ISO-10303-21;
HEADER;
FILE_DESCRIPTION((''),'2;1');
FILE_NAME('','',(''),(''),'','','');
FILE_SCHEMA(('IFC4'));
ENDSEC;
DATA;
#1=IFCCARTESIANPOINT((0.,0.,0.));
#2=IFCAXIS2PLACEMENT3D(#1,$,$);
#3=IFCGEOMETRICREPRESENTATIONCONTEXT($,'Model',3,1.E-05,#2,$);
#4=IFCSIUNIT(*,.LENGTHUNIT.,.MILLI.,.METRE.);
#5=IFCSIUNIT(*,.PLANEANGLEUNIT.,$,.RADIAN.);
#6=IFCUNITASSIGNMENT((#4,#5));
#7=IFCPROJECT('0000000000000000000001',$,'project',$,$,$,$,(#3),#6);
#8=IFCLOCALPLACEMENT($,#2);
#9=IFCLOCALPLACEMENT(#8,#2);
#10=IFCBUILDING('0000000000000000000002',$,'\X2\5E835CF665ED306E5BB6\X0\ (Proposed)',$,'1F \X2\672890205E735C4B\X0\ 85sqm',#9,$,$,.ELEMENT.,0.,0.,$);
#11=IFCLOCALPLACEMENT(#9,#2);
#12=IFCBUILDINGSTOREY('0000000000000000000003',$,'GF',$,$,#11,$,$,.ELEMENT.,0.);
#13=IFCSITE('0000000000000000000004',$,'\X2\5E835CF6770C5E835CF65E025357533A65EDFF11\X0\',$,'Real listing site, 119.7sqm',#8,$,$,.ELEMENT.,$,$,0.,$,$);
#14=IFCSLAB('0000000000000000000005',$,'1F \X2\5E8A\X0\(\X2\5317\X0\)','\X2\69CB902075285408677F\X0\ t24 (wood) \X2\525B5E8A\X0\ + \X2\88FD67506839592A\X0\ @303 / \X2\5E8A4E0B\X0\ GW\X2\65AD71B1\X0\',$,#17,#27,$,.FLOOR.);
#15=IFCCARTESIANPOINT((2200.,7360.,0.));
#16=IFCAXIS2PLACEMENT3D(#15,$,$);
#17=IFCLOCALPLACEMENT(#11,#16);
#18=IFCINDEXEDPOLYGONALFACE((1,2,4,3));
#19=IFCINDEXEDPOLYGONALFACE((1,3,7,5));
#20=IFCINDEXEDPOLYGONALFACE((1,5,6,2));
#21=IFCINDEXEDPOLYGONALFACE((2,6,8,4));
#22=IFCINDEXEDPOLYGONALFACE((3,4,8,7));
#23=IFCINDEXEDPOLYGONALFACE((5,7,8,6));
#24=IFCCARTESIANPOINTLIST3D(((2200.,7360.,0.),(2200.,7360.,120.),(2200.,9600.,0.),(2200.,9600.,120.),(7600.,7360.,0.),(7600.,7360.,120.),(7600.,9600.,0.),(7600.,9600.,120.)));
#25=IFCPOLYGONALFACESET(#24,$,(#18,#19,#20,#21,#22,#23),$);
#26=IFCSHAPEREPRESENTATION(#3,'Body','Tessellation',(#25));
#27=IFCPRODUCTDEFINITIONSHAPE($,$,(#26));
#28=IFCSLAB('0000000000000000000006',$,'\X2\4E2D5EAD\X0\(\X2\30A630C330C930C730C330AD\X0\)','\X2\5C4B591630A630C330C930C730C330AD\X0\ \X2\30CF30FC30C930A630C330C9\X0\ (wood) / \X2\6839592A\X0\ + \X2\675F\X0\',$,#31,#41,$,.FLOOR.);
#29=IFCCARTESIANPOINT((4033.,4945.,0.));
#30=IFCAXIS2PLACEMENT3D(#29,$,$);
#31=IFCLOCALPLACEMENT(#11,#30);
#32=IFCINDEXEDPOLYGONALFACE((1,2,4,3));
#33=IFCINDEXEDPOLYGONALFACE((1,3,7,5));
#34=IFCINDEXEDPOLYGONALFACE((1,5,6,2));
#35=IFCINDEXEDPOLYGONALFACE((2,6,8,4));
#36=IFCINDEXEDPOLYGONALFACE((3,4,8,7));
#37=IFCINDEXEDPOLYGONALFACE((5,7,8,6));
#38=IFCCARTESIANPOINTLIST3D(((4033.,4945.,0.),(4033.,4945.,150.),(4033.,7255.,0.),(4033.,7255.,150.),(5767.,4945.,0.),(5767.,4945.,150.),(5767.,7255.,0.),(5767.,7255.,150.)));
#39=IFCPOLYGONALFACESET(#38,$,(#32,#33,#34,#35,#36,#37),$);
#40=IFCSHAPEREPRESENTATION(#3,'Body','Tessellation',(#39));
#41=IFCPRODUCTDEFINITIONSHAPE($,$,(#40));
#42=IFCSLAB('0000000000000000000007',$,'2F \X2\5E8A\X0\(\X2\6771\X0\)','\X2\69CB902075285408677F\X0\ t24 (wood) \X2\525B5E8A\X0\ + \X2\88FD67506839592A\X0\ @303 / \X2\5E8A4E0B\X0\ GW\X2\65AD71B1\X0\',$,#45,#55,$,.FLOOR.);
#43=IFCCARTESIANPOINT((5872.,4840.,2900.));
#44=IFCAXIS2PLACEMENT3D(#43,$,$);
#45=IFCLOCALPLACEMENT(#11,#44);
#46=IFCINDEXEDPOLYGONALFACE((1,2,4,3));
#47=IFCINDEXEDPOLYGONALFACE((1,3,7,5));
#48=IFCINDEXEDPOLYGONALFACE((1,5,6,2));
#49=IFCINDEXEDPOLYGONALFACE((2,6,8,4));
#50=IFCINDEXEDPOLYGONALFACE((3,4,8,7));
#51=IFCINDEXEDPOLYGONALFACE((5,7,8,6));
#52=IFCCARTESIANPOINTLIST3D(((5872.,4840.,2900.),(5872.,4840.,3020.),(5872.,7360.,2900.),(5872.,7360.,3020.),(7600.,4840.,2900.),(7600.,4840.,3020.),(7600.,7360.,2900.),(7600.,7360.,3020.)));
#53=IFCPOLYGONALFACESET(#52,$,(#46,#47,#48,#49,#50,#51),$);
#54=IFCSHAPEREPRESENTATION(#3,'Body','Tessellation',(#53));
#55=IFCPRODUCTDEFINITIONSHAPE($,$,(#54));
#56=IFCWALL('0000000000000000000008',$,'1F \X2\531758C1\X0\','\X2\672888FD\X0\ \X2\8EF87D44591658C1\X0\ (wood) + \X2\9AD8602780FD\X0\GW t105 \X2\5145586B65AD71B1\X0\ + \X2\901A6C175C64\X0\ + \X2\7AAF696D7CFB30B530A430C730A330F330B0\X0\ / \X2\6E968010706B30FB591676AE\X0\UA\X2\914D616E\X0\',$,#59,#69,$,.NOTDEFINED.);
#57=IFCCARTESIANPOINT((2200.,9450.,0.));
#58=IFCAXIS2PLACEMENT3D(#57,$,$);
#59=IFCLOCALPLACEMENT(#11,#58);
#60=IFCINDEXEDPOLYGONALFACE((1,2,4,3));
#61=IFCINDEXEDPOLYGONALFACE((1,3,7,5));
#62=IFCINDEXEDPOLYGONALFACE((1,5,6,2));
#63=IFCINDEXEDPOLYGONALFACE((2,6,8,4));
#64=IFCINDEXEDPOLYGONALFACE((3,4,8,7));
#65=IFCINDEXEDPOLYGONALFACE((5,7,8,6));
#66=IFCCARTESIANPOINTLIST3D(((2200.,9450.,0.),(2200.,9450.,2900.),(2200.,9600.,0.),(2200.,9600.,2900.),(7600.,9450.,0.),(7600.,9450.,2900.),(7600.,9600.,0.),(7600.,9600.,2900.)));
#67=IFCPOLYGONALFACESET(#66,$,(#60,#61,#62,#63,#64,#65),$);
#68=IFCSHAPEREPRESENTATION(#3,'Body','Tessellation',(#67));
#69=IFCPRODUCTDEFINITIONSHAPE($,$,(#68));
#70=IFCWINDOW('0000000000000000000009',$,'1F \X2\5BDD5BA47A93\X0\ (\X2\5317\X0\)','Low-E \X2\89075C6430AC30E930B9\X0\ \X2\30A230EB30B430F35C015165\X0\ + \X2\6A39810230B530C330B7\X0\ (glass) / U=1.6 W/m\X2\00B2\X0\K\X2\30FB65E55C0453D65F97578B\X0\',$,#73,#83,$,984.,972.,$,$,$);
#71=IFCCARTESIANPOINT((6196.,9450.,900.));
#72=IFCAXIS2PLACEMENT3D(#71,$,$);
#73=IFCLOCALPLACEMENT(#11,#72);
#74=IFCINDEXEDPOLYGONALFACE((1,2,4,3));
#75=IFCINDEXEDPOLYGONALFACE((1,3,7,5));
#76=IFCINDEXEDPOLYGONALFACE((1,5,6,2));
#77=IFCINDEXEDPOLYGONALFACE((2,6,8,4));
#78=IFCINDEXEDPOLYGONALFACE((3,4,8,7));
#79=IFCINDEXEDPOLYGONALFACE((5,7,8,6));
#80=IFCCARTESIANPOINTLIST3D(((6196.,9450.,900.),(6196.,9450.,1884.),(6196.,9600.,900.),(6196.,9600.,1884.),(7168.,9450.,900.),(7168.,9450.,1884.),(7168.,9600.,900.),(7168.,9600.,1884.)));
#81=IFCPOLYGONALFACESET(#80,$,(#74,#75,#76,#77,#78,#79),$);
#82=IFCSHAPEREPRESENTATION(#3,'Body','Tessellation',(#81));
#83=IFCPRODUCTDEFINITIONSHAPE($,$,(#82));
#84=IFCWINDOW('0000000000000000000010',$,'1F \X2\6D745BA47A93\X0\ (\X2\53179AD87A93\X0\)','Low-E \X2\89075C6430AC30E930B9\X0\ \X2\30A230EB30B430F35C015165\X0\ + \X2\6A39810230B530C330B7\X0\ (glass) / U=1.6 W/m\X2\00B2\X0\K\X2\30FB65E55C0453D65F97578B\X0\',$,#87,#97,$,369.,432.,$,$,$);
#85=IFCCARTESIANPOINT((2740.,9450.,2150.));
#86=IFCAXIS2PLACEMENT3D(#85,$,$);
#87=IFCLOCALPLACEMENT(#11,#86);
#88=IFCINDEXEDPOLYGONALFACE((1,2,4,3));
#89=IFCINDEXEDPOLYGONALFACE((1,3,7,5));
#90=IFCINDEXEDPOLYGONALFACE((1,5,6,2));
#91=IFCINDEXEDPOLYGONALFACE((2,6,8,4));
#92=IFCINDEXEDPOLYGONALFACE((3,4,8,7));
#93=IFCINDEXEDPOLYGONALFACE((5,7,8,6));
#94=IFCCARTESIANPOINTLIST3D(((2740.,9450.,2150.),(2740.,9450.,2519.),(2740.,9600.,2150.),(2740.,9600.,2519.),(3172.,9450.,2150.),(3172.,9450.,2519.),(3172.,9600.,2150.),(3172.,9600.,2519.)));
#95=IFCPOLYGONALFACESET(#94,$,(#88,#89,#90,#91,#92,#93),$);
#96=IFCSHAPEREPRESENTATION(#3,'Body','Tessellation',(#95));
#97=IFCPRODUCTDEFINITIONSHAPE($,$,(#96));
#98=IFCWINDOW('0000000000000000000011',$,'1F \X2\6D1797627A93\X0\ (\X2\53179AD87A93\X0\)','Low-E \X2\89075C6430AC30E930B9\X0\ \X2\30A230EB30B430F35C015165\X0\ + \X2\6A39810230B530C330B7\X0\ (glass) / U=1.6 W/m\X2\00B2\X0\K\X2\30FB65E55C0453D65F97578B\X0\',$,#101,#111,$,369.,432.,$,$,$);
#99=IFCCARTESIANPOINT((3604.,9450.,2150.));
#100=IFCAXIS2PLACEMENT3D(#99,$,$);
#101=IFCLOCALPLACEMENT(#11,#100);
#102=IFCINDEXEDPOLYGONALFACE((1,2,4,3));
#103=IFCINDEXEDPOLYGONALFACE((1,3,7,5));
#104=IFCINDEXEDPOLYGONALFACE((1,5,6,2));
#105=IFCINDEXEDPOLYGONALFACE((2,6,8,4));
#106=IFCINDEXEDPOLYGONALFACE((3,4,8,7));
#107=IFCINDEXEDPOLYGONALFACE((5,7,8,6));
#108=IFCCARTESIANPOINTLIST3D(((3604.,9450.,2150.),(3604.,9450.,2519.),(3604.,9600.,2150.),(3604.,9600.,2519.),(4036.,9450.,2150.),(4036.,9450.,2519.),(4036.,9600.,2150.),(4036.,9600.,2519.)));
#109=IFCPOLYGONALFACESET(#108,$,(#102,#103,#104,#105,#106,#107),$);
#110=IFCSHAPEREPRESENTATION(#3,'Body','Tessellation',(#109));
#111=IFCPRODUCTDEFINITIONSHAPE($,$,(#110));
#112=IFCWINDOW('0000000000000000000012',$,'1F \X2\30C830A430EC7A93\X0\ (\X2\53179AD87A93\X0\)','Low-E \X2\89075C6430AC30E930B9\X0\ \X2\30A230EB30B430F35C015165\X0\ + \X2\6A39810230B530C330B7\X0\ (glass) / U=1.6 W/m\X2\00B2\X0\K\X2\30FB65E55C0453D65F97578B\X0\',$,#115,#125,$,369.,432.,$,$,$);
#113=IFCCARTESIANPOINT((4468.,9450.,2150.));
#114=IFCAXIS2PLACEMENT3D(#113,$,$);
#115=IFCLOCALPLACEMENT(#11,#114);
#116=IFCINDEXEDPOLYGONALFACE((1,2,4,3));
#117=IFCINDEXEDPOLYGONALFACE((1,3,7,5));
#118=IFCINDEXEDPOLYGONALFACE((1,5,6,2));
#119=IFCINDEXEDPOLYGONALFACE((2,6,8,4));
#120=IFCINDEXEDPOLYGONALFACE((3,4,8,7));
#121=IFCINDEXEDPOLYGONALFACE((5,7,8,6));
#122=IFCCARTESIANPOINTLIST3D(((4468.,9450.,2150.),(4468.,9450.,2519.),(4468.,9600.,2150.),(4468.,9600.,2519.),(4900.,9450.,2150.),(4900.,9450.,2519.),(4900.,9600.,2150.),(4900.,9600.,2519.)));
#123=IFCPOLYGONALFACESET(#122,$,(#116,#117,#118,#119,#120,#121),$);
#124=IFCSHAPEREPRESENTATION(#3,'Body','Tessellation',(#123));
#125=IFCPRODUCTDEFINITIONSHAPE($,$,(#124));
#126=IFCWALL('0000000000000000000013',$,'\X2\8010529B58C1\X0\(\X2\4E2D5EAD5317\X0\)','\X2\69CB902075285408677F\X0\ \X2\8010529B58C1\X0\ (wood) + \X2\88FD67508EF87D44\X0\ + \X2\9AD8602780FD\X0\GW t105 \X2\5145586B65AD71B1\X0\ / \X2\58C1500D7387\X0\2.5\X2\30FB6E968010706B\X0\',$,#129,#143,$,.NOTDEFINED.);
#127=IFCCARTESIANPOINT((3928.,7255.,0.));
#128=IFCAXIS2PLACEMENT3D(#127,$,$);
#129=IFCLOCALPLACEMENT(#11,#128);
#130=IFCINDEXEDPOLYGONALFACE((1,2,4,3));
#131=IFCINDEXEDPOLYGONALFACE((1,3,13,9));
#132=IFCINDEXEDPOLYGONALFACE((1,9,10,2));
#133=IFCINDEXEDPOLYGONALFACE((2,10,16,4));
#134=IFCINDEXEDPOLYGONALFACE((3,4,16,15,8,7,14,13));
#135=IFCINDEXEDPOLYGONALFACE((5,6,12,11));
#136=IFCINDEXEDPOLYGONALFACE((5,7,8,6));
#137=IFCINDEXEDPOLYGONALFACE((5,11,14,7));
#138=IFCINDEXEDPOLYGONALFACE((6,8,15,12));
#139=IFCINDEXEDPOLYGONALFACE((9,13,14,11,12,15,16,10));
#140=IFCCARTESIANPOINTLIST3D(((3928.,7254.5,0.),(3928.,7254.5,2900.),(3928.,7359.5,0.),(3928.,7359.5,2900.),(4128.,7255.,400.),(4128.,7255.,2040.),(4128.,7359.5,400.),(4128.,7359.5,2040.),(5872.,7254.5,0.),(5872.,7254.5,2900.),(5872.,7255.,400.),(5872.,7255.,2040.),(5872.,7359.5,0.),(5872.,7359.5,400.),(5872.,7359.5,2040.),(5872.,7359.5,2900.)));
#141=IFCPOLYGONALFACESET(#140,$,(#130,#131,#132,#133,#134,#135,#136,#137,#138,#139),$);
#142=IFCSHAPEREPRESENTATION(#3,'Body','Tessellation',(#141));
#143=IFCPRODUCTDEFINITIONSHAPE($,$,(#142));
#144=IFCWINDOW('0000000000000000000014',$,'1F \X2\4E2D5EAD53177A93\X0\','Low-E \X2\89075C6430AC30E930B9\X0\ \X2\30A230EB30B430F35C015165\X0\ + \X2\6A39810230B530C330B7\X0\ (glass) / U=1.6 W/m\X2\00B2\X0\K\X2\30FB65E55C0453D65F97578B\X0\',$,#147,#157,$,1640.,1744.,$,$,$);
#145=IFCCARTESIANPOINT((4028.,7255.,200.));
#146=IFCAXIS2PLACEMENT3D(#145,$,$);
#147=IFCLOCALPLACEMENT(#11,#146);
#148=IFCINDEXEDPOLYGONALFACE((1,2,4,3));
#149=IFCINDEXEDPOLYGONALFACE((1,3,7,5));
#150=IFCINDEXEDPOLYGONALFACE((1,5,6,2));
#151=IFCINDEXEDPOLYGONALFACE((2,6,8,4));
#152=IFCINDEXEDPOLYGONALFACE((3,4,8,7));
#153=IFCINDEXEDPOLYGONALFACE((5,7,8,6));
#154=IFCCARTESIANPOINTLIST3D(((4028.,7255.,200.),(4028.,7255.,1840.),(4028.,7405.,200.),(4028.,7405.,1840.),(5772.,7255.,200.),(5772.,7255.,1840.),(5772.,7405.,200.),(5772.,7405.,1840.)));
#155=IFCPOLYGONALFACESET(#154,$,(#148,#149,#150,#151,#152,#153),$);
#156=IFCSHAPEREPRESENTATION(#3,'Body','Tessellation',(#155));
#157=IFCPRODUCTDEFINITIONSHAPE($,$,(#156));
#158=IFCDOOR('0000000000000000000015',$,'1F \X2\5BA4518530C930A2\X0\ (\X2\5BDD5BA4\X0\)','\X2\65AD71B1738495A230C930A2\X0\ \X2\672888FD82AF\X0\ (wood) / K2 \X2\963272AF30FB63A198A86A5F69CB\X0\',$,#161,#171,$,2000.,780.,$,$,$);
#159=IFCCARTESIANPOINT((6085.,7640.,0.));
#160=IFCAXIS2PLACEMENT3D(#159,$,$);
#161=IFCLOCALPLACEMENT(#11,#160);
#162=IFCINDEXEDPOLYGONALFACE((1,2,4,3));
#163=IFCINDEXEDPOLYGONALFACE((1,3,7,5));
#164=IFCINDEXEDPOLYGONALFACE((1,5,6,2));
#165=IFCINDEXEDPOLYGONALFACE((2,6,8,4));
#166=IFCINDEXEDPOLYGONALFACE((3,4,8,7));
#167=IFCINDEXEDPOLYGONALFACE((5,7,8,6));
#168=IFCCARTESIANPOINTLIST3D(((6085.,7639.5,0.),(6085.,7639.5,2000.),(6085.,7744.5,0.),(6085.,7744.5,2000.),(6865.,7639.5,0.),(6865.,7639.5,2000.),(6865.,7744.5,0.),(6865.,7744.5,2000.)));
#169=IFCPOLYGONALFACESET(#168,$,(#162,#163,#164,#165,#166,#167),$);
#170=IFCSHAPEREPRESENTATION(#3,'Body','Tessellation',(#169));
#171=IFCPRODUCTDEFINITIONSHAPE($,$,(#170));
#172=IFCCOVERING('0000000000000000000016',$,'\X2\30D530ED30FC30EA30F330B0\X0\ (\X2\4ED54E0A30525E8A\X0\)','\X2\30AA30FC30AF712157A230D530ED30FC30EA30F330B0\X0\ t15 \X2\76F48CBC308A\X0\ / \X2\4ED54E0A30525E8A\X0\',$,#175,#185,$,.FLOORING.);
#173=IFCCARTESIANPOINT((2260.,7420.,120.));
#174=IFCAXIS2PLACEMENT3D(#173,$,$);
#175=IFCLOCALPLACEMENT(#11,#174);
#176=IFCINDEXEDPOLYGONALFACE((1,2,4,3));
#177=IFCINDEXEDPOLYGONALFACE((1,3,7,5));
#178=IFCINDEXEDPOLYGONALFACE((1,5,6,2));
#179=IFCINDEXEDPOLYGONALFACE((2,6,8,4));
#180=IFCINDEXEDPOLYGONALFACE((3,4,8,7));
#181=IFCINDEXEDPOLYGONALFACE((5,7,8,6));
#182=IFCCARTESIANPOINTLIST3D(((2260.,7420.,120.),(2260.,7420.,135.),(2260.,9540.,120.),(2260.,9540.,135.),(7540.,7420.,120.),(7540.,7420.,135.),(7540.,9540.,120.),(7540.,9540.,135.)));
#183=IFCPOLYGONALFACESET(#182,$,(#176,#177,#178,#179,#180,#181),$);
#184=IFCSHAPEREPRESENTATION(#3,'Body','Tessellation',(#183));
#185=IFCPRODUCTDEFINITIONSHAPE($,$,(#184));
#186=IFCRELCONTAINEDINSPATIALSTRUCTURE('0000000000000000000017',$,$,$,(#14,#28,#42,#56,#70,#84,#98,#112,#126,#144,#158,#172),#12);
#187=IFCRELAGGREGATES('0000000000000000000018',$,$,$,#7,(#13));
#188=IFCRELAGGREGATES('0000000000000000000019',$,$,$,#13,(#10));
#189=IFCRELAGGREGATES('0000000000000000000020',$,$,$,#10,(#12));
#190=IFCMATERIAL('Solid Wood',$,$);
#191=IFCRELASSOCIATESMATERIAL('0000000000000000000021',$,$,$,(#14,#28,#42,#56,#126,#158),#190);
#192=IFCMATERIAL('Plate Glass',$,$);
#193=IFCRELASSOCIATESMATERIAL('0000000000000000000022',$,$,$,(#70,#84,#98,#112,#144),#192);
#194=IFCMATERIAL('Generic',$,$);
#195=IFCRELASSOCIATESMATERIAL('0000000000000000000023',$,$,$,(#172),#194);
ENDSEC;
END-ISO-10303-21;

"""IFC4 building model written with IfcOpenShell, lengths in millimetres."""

from ifc_helpers import new_model, si_unit, frame, frame_2d, origin, place, context, project, spatial, rectangle, extrude, material, element, fill, save


model = new_model("IFC4")

# Units and contexts
model_context = context("Model", 3, precision=1e-05, world=origin())
ifc_project = project(units=[si_unit("LENGTHUNIT", "METRE", prefix="MILLI"), si_unit("PLANEANGLEUNIT", "RADIAN")], contexts=[model_context])

# Site, building, storey
site_placement = place(None, origin())
site = spatial("IfcSite", under=ifc_project, at=site_placement, Name="広島県広島市南区旭１", ObjectType="Real listing site, 119.7sqm", CompositionType="ELEMENT", RefElevation=0.0)
building_placement = place(site_placement, origin())
building = spatial("IfcBuilding", under=site, at=building_placement, Name="広島旭の家 (Proposed)", ObjectType="1F 木造平屋 85sqm", CompositionType="ELEMENT", ElevationOfRefHeight=0.0, ElevationOfTerrain=0.0)
storey_placement = place(building_placement, origin())
storey = spatial("IfcBuildingStorey", under=building, at=storey_placement, Name="GF", CompositionType="ELEMENT", Elevation=0.0)

# Slabs
ifc_material_1 = material(Name="Solid Wood")
slab_1_placement = place(storey_placement, frame((2200.0, 7360.0, 0.0)))
element("IfcSlab", 1, at=slab_1_placement, inside=storey, material=ifc_material_1, Name="1F 床(北)", Description="構造用合板 t24 (wood) 剛床 + 製材根太 @303 / 床下 GW断熱", PredefinedType="FLOOR", context=model_context, shape_type="SweptSolid", body=[
    extrude(rectangle(XDim=5400.0, YDim=2240.0, at=frame_2d((2700.0, 1120.0))), frame((2200.0, 7360.0, 0.0)), (0.0, 0.0, 1.0), 120.0),
])
slab_2_placement = place(storey_placement, frame((4033.0, 4945.0, 0.0)))
element("IfcSlab", 2, at=slab_2_placement, inside=storey, material=ifc_material_1, Name="中庭(ウッドデッキ)", Description="屋外ウッドデッキ ハードウッド (wood) / 根太 + 束", PredefinedType="FLOOR", context=model_context, shape_type="SweptSolid", body=[
    extrude(rectangle(XDim=1734.0, YDim=2310.0, at=frame_2d((867.0, 1155.0))), frame((4033.0, 4945.0, 0.0)), (0.0, 0.0, 1.0), 150.0),
])
slab_3_placement = place(storey_placement, frame((5872.0, 4840.0, 2900.0)))
element("IfcSlab", 3, at=slab_3_placement, inside=storey, material=ifc_material_1, Name="2F 床(東)", Description="構造用合板 t24 (wood) 剛床 + 製材根太 @303 / 床下 GW断熱", PredefinedType="FLOOR", context=model_context, shape_type="SweptSolid", body=[
    extrude(rectangle(XDim=1728.0, YDim=2520.0, at=frame_2d((864.0, 1260.0))), frame((5872.0, 4840.0, 2900.0)), (0.0, 0.0, 1.0), 120.0),
])

# Wall, openings, windows
wall_1_placement = place(storey_placement, frame((2200.0, 9450.0, 0.0)))
wall_1 = element("IfcWall", 4, at=wall_1_placement, inside=storey, material=ifc_material_1, Name="1F 北壁", Description="木製 軸組外壁 (wood) + 高性能GW t105 充填断熱 + 通気層 + 窯業系サイディング / 準耐火・外皮UA配慮", PredefinedType="NOTDEFINED", context=model_context, shape_type="SweptSolid", body=[
    extrude(rectangle(XDim=5400.0, YDim=150.0, at=frame_2d((2700.0, 75.0))), frame((2200.0, 9450.0, 0.0)), (0.0, 0.0, 1.0), 2900.0),
])
opening_1_placement = place(storey_placement, frame((6196.0, 9450.0, 900.0)))
opening_1 = element("IfcOpeningElement", 5, at=opening_1_placement, cuts=wall_1, PredefinedType="NOTDEFINED", context=model_context, shape_type="SweptSolid", body=[
    extrude(rectangle(XDim=972.0, YDim=150.0, at=frame_2d((486.0, 75.0))), frame((6196.0, 9450.0, 900.0)), (0.0, 0.0, 1.0), 984.0),
])
opening_2_placement = place(storey_placement, frame((2740.0, 9450.0, 2150.0)))
opening_2 = element("IfcOpeningElement", 6, at=opening_2_placement, cuts=wall_1, PredefinedType="NOTDEFINED", context=model_context, shape_type="SweptSolid", body=[
    extrude(rectangle(XDim=432.0, YDim=150.0, at=frame_2d((216.0, 75.0))), frame((2740.0, 9450.0, 2150.0)), (0.0, 0.0, 1.0), 369.0),
])
opening_3_placement = place(storey_placement, frame((3604.0, 9450.0, 2150.0)))
opening_3 = element("IfcOpeningElement", 7, at=opening_3_placement, cuts=wall_1, PredefinedType="NOTDEFINED", context=model_context, shape_type="SweptSolid", body=[
    extrude(rectangle(XDim=432.0, YDim=150.0, at=frame_2d((216.0, 75.0))), frame((3604.0, 9450.0, 2150.0)), (0.0, 0.0, 1.0), 369.0),
])
opening_4_placement = place(storey_placement, frame((4468.0, 9450.0, 2150.0)))
opening_4 = element("IfcOpeningElement", 8, at=opening_4_placement, cuts=wall_1, PredefinedType="NOTDEFINED", context=model_context, shape_type="SweptSolid", body=[
    extrude(rectangle(XDim=432.0, YDim=150.0, at=frame_2d((216.0, 75.0))), frame((4468.0, 9450.0, 2150.0)), (0.0, 0.0, 1.0), 369.0),
])
ifc_material_2 = material(Name="Plate Glass")
window_1_placement = place(storey_placement, frame((6196.0, 9450.0, 900.0)))
window_1 = element("IfcWindow", 9, at=window_1_placement, inside=storey, material=ifc_material_2, Name="1F 寝室窓 (北)", Description="Low-E 複層ガラス アルゴン封入 + 樹脂サッシ (glass) / U=1.6 W/m²K・日射取得型", OverallHeight=984.0, OverallWidth=972.0, context=model_context, shape_type="SweptSolid", body=[
    extrude(rectangle(XDim=972.0, YDim=150.0, at=frame_2d((486.0, 75.0))), frame((6196.0, 9450.0, 900.0)), (0.0, 0.0, 1.0), 984.0),
])
fill(opening_1, window_1)
window_2_placement = place(storey_placement, frame((2740.0, 9450.0, 2150.0)))
window_2 = element("IfcWindow", 10, at=window_2_placement, inside=storey, material=ifc_material_2, Name="1F 浴室窓 (北高窓)", Description="Low-E 複層ガラス アルゴン封入 + 樹脂サッシ (glass) / U=1.6 W/m²K・日射取得型", OverallHeight=369.0, OverallWidth=432.0, context=model_context, shape_type="SweptSolid", body=[
    extrude(rectangle(XDim=432.0, YDim=150.0, at=frame_2d((216.0, 75.0))), frame((2740.0, 9450.0, 2150.0)), (0.0, 0.0, 1.0), 369.0),
])
fill(opening_2, window_2)
window_3_placement = place(storey_placement, frame((3604.0, 9450.0, 2150.0)))
window_3 = element("IfcWindow", 11, at=window_3_placement, inside=storey, material=ifc_material_2, Name="1F 洗面窓 (北高窓)", Description="Low-E 複層ガラス アルゴン封入 + 樹脂サッシ (glass) / U=1.6 W/m²K・日射取得型", OverallHeight=369.0, OverallWidth=432.0, context=model_context, shape_type="SweptSolid", body=[
    extrude(rectangle(XDim=432.0, YDim=150.0, at=frame_2d((216.0, 75.0))), frame((3604.0, 9450.0, 2150.0)), (0.0, 0.0, 1.0), 369.0),
])
fill(opening_3, window_3)
window_4_placement = place(storey_placement, frame((4468.0, 9450.0, 2150.0)))
window_4 = element("IfcWindow", 12, at=window_4_placement, inside=storey, material=ifc_material_2, Name="1F トイレ窓 (北高窓)", Description="Low-E 複層ガラス アルゴン封入 + 樹脂サッシ (glass) / U=1.6 W/m²K・日射取得型", OverallHeight=369.0, OverallWidth=432.0, context=model_context, shape_type="SweptSolid", body=[
    extrude(rectangle(XDim=432.0, YDim=150.0, at=frame_2d((216.0, 75.0))), frame((4468.0, 9450.0, 2150.0)), (0.0, 0.0, 1.0), 369.0),
])
fill(opening_4, window_4)

# Wall, opening, window
wall_2_placement = place(storey_placement, frame((3928.0, 7255.0, 0.0)))
wall_2 = element("IfcWall", 13, at=wall_2_placement, inside=storey, material=ifc_material_1, Name="耐力壁(中庭北)", Description="構造用合板 耐力壁 (wood) + 製材軸組 + 高性能GW t105 充填断熱 / 壁倍率2.5・準耐火", PredefinedType="NOTDEFINED", context=model_context, shape_type="SweptSolid", body=[
    extrude(rectangle(XDim=1944.0, YDim=105.0, at=frame_2d((972.0, 52.0))), frame((3928.0, 7255.0, 0.0)), (0.0, 0.0, 1.0), 2900.0),
])
opening_5_placement = place(storey_placement, frame((4028.0, 7255.0, 200.0)))
opening_5 = element("IfcOpeningElement", 14, at=opening_5_placement, cuts=wall_2, PredefinedType="NOTDEFINED", context=model_context, shape_type="SweptSolid", body=[
    extrude(rectangle(XDim=1744.0, YDim=150.0, at=frame_2d((872.0, 75.0))), frame((4028.0, 7255.0, 200.0)), (0.0, 0.0, 1.0), 1640.0),
])
window_5_placement = place(storey_placement, frame((4028.0, 7255.0, 200.0)))
window_5 = element("IfcWindow", 15, at=window_5_placement, inside=storey, material=ifc_material_2, Name="1F 中庭北窓", Description="Low-E 複層ガラス アルゴン封入 + 樹脂サッシ (glass) / U=1.6 W/m²K・日射取得型", OverallHeight=1640.0, OverallWidth=1744.0, context=model_context, shape_type="SweptSolid", body=[
    extrude(rectangle(XDim=1744.0, YDim=150.0, at=frame_2d((872.0, 75.0))), frame((4028.0, 7255.0, 200.0)), (0.0, 0.0, 1.0), 1640.0),
])
fill(opening_5, window_5)

# Door
door_1_placement = place(storey_placement, frame((6085.0, 7640.0, 0.0)))
element("IfcDoor", 16, at=door_1_placement, inside=storey, material=ifc_material_1, Name="1F 室内ドア (寝室)", Description="断熱玄関ドア 木製芯 (wood) / K2 防犯・採風機構", OverallHeight=2000.0, OverallWidth=780.0, context=model_context, shape_type="SweptSolid", body=[
    extrude(rectangle(XDim=780.0, YDim=105.0, at=frame_2d((390.0, 52.0))), frame((6085.0, 7640.0, 0.0)), (0.0, 0.0, 1.0), 2000.0),
])

# Covering
ifc_material_3 = material(Name="Generic")
covering_1_placement = place(storey_placement, frame((2260.0, 7420.0, 120.0)))
element("IfcCovering", 17, at=covering_1_placement, inside=storey, material=ifc_material_3, Name="フローリング (仕上げ床)", Description="オーク無垢フローリング t15 直貼り / 仕上げ床", PredefinedType="FLOORING", context=model_context, shape_type="SweptSolid", body=[
    extrude(rectangle(XDim=5280.0, YDim=2120.0, at=frame_2d((2640.0, 1060.0))), frame((2260.0, 7420.0, 120.0)), (0.0, 0.0, 1.0), 15.0),
])

save(model, "model.ifc")
